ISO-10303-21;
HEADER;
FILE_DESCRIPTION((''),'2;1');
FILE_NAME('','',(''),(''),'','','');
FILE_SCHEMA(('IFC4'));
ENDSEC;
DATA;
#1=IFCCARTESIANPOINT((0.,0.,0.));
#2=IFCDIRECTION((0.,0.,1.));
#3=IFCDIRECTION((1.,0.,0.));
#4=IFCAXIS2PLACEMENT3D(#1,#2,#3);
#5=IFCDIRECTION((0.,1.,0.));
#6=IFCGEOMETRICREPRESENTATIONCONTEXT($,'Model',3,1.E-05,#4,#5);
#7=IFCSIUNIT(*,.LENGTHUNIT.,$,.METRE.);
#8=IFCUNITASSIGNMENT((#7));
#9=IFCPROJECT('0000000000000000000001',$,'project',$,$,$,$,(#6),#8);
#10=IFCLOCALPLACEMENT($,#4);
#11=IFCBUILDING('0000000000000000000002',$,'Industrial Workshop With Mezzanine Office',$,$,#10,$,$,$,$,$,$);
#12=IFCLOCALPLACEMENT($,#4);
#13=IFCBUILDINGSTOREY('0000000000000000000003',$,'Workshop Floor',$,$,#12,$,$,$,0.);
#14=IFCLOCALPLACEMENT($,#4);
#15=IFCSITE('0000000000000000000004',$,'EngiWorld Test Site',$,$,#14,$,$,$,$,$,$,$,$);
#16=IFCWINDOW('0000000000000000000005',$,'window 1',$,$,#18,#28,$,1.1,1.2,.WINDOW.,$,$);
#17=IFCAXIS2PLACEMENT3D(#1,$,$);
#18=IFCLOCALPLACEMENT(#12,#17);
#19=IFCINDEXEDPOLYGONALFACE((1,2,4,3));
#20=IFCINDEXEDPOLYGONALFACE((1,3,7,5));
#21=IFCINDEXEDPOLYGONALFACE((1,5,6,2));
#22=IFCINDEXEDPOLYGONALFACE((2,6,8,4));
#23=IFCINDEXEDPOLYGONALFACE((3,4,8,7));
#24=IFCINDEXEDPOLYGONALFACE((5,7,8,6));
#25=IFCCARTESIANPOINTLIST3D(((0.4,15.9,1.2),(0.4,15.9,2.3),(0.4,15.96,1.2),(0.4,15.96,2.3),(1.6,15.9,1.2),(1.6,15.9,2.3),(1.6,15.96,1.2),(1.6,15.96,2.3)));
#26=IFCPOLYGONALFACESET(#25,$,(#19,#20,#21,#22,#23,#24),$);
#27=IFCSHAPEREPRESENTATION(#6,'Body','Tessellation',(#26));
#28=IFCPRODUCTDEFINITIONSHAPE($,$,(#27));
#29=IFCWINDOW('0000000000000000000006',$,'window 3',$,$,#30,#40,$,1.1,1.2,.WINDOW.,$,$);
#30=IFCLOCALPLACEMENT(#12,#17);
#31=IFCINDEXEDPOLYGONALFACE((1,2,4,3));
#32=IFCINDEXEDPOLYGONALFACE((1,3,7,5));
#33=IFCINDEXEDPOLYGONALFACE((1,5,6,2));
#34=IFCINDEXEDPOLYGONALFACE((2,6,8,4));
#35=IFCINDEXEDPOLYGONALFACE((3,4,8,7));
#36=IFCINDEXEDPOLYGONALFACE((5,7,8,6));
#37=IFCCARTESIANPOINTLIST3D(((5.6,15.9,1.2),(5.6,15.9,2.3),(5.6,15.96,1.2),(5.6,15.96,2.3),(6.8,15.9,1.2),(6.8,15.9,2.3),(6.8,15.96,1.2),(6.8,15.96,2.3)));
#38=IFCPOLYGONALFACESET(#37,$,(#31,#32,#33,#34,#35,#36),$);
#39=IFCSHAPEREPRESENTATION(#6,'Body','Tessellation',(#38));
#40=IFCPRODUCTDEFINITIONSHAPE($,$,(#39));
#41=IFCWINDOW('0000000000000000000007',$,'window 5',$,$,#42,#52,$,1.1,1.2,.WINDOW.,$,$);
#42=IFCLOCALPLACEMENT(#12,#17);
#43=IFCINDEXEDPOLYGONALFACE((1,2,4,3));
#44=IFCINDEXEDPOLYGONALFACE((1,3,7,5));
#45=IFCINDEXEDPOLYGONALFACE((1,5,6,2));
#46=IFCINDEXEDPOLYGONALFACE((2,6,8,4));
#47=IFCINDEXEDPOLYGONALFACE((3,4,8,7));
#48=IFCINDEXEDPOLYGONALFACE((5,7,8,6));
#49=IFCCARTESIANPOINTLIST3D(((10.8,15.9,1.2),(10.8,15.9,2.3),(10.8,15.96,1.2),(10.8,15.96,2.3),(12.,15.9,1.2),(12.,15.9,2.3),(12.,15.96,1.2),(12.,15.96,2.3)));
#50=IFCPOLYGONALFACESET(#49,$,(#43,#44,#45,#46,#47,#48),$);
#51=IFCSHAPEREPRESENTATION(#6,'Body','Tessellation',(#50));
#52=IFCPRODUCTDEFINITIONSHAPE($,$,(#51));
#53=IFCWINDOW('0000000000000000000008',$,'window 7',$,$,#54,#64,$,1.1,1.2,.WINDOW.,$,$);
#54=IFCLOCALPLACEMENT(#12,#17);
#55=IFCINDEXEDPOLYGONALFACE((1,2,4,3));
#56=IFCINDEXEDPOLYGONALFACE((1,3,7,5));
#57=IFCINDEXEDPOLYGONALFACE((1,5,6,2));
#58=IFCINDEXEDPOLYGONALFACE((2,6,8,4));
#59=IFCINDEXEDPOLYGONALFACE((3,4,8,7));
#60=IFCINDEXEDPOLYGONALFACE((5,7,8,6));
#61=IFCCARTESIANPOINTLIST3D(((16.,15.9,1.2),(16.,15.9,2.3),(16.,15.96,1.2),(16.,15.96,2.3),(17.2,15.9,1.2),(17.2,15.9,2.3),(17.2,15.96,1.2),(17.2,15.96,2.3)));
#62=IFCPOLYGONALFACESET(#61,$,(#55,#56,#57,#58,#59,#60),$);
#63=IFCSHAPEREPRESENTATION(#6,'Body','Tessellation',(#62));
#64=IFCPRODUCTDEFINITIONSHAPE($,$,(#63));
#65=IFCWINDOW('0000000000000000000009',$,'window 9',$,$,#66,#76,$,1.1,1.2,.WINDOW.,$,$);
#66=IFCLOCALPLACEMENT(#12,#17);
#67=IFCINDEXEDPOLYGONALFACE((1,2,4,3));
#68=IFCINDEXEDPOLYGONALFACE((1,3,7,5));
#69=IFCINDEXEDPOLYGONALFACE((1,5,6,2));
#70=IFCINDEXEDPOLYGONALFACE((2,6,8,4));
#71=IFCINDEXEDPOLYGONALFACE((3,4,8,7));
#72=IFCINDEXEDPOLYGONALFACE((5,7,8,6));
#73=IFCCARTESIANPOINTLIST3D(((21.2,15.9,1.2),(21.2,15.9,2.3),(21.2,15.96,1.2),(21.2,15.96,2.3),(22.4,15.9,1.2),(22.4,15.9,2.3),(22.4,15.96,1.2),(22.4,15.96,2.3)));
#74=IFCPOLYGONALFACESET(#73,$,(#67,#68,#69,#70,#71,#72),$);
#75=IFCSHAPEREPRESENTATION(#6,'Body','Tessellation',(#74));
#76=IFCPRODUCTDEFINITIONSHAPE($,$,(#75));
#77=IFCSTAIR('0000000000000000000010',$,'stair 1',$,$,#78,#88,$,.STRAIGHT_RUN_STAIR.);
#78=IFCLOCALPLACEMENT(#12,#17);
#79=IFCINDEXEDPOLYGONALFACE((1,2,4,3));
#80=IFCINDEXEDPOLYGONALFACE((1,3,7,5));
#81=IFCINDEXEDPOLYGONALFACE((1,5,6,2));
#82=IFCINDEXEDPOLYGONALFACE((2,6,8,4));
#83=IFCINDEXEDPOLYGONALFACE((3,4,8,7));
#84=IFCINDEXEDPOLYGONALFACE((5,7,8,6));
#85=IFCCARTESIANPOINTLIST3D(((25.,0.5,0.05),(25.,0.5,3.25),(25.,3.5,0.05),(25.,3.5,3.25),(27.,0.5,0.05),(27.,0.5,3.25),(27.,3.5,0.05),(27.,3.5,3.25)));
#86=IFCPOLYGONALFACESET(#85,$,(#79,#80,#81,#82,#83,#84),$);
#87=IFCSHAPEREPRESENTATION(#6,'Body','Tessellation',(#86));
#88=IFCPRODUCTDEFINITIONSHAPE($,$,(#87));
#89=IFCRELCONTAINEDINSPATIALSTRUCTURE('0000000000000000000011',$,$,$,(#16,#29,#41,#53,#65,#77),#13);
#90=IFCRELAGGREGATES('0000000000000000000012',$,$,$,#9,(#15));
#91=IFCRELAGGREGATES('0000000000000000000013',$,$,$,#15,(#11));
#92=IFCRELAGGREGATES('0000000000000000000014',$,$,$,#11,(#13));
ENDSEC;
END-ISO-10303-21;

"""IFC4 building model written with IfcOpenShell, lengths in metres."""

from ifc_helpers import new_model, si_unit, direction, frame, origin_with_axes, origin_2d_with_axis, place, context, project, spatial, rectangle, extrude, element, save


model = new_model("IFC4")

# Units and contexts
model_context = context("Model", 3, precision=1e-05, world=origin_with_axes(), true_north=direction((0.0, 1.0, 0.0)))
ifc_project = project(units=[si_unit("LENGTHUNIT", "METRE")], contexts=[model_context])

# Site, building, storey
site_placement = place(None, origin_with_axes())
site = spatial("IfcSite", under=ifc_project, at=site_placement, Name="EngiWorld Test Site")
building_placement = place(None, origin_with_axes())
building = spatial("IfcBuilding", under=site, at=building_placement, Name="Industrial Workshop With Mezzanine Office")
storey_placement = place(None, origin_with_axes())
storey = spatial("IfcBuildingStorey", under=building, at=storey_placement, Name="Workshop Floor", Elevation=0.0)

# Windows
for number, where, z_axis, x_axis, name in (
    (1, (1.0, 15.93, 1.2), (0.0, 0.0, 1.0), (1.0, 0.0, 0.0), "window 1"),
    (2, (6.2, 15.93, 1.2), (0.0, 0.0, 1.0), (1.0, 0.0, 0.0), "window 3"),
    (3, (11.4, 15.93, 1.2), (0.0, 0.0, 1.0), (1.0, 0.0, 0.0), "window 5"),
    (4, (16.6, 15.93, 1.2), (0.0, 0.0, 1.0), (1.0, 0.0, 0.0), "window 7"),
    (5, (21.8, 15.93, 1.2), (0.0, 0.0, 1.0), (1.0, 0.0, 0.0), "window 9"),
):
    element("IfcWindow", number, at=place(None, frame(where, z_axis=z_axis, x_axis=x_axis)), inside=storey, Name=name, OverallHeight=1.1, OverallWidth=1.2, PredefinedType="WINDOW", context=model_context, shape_type="SweptSolid", body=[
        extrude(rectangle(XDim=1.2, YDim=0.06, at=origin_2d_with_axis()), origin_with_axes(), (0.0, 0.0, 1.0), 1.1),
    ])

# Stair
stair_placement = place(None, frame((26.0, 2.0, 0.05), z_axis=(0.0, 0.0, 1.0), x_axis=(1.0, 0.0, 0.0)))
element("IfcStair", 6, at=stair_placement, inside=storey, Name="stair 1", PredefinedType="STRAIGHT_RUN_STAIR", context=model_context, shape_type="SweptSolid", body=[
    extrude(rectangle(XDim=2.0, YDim=3.0, at=origin_2d_with_axis()), origin_with_axes(), (0.0, 0.0, 1.0), 3.2),
])

save(model, "model.ifc")
